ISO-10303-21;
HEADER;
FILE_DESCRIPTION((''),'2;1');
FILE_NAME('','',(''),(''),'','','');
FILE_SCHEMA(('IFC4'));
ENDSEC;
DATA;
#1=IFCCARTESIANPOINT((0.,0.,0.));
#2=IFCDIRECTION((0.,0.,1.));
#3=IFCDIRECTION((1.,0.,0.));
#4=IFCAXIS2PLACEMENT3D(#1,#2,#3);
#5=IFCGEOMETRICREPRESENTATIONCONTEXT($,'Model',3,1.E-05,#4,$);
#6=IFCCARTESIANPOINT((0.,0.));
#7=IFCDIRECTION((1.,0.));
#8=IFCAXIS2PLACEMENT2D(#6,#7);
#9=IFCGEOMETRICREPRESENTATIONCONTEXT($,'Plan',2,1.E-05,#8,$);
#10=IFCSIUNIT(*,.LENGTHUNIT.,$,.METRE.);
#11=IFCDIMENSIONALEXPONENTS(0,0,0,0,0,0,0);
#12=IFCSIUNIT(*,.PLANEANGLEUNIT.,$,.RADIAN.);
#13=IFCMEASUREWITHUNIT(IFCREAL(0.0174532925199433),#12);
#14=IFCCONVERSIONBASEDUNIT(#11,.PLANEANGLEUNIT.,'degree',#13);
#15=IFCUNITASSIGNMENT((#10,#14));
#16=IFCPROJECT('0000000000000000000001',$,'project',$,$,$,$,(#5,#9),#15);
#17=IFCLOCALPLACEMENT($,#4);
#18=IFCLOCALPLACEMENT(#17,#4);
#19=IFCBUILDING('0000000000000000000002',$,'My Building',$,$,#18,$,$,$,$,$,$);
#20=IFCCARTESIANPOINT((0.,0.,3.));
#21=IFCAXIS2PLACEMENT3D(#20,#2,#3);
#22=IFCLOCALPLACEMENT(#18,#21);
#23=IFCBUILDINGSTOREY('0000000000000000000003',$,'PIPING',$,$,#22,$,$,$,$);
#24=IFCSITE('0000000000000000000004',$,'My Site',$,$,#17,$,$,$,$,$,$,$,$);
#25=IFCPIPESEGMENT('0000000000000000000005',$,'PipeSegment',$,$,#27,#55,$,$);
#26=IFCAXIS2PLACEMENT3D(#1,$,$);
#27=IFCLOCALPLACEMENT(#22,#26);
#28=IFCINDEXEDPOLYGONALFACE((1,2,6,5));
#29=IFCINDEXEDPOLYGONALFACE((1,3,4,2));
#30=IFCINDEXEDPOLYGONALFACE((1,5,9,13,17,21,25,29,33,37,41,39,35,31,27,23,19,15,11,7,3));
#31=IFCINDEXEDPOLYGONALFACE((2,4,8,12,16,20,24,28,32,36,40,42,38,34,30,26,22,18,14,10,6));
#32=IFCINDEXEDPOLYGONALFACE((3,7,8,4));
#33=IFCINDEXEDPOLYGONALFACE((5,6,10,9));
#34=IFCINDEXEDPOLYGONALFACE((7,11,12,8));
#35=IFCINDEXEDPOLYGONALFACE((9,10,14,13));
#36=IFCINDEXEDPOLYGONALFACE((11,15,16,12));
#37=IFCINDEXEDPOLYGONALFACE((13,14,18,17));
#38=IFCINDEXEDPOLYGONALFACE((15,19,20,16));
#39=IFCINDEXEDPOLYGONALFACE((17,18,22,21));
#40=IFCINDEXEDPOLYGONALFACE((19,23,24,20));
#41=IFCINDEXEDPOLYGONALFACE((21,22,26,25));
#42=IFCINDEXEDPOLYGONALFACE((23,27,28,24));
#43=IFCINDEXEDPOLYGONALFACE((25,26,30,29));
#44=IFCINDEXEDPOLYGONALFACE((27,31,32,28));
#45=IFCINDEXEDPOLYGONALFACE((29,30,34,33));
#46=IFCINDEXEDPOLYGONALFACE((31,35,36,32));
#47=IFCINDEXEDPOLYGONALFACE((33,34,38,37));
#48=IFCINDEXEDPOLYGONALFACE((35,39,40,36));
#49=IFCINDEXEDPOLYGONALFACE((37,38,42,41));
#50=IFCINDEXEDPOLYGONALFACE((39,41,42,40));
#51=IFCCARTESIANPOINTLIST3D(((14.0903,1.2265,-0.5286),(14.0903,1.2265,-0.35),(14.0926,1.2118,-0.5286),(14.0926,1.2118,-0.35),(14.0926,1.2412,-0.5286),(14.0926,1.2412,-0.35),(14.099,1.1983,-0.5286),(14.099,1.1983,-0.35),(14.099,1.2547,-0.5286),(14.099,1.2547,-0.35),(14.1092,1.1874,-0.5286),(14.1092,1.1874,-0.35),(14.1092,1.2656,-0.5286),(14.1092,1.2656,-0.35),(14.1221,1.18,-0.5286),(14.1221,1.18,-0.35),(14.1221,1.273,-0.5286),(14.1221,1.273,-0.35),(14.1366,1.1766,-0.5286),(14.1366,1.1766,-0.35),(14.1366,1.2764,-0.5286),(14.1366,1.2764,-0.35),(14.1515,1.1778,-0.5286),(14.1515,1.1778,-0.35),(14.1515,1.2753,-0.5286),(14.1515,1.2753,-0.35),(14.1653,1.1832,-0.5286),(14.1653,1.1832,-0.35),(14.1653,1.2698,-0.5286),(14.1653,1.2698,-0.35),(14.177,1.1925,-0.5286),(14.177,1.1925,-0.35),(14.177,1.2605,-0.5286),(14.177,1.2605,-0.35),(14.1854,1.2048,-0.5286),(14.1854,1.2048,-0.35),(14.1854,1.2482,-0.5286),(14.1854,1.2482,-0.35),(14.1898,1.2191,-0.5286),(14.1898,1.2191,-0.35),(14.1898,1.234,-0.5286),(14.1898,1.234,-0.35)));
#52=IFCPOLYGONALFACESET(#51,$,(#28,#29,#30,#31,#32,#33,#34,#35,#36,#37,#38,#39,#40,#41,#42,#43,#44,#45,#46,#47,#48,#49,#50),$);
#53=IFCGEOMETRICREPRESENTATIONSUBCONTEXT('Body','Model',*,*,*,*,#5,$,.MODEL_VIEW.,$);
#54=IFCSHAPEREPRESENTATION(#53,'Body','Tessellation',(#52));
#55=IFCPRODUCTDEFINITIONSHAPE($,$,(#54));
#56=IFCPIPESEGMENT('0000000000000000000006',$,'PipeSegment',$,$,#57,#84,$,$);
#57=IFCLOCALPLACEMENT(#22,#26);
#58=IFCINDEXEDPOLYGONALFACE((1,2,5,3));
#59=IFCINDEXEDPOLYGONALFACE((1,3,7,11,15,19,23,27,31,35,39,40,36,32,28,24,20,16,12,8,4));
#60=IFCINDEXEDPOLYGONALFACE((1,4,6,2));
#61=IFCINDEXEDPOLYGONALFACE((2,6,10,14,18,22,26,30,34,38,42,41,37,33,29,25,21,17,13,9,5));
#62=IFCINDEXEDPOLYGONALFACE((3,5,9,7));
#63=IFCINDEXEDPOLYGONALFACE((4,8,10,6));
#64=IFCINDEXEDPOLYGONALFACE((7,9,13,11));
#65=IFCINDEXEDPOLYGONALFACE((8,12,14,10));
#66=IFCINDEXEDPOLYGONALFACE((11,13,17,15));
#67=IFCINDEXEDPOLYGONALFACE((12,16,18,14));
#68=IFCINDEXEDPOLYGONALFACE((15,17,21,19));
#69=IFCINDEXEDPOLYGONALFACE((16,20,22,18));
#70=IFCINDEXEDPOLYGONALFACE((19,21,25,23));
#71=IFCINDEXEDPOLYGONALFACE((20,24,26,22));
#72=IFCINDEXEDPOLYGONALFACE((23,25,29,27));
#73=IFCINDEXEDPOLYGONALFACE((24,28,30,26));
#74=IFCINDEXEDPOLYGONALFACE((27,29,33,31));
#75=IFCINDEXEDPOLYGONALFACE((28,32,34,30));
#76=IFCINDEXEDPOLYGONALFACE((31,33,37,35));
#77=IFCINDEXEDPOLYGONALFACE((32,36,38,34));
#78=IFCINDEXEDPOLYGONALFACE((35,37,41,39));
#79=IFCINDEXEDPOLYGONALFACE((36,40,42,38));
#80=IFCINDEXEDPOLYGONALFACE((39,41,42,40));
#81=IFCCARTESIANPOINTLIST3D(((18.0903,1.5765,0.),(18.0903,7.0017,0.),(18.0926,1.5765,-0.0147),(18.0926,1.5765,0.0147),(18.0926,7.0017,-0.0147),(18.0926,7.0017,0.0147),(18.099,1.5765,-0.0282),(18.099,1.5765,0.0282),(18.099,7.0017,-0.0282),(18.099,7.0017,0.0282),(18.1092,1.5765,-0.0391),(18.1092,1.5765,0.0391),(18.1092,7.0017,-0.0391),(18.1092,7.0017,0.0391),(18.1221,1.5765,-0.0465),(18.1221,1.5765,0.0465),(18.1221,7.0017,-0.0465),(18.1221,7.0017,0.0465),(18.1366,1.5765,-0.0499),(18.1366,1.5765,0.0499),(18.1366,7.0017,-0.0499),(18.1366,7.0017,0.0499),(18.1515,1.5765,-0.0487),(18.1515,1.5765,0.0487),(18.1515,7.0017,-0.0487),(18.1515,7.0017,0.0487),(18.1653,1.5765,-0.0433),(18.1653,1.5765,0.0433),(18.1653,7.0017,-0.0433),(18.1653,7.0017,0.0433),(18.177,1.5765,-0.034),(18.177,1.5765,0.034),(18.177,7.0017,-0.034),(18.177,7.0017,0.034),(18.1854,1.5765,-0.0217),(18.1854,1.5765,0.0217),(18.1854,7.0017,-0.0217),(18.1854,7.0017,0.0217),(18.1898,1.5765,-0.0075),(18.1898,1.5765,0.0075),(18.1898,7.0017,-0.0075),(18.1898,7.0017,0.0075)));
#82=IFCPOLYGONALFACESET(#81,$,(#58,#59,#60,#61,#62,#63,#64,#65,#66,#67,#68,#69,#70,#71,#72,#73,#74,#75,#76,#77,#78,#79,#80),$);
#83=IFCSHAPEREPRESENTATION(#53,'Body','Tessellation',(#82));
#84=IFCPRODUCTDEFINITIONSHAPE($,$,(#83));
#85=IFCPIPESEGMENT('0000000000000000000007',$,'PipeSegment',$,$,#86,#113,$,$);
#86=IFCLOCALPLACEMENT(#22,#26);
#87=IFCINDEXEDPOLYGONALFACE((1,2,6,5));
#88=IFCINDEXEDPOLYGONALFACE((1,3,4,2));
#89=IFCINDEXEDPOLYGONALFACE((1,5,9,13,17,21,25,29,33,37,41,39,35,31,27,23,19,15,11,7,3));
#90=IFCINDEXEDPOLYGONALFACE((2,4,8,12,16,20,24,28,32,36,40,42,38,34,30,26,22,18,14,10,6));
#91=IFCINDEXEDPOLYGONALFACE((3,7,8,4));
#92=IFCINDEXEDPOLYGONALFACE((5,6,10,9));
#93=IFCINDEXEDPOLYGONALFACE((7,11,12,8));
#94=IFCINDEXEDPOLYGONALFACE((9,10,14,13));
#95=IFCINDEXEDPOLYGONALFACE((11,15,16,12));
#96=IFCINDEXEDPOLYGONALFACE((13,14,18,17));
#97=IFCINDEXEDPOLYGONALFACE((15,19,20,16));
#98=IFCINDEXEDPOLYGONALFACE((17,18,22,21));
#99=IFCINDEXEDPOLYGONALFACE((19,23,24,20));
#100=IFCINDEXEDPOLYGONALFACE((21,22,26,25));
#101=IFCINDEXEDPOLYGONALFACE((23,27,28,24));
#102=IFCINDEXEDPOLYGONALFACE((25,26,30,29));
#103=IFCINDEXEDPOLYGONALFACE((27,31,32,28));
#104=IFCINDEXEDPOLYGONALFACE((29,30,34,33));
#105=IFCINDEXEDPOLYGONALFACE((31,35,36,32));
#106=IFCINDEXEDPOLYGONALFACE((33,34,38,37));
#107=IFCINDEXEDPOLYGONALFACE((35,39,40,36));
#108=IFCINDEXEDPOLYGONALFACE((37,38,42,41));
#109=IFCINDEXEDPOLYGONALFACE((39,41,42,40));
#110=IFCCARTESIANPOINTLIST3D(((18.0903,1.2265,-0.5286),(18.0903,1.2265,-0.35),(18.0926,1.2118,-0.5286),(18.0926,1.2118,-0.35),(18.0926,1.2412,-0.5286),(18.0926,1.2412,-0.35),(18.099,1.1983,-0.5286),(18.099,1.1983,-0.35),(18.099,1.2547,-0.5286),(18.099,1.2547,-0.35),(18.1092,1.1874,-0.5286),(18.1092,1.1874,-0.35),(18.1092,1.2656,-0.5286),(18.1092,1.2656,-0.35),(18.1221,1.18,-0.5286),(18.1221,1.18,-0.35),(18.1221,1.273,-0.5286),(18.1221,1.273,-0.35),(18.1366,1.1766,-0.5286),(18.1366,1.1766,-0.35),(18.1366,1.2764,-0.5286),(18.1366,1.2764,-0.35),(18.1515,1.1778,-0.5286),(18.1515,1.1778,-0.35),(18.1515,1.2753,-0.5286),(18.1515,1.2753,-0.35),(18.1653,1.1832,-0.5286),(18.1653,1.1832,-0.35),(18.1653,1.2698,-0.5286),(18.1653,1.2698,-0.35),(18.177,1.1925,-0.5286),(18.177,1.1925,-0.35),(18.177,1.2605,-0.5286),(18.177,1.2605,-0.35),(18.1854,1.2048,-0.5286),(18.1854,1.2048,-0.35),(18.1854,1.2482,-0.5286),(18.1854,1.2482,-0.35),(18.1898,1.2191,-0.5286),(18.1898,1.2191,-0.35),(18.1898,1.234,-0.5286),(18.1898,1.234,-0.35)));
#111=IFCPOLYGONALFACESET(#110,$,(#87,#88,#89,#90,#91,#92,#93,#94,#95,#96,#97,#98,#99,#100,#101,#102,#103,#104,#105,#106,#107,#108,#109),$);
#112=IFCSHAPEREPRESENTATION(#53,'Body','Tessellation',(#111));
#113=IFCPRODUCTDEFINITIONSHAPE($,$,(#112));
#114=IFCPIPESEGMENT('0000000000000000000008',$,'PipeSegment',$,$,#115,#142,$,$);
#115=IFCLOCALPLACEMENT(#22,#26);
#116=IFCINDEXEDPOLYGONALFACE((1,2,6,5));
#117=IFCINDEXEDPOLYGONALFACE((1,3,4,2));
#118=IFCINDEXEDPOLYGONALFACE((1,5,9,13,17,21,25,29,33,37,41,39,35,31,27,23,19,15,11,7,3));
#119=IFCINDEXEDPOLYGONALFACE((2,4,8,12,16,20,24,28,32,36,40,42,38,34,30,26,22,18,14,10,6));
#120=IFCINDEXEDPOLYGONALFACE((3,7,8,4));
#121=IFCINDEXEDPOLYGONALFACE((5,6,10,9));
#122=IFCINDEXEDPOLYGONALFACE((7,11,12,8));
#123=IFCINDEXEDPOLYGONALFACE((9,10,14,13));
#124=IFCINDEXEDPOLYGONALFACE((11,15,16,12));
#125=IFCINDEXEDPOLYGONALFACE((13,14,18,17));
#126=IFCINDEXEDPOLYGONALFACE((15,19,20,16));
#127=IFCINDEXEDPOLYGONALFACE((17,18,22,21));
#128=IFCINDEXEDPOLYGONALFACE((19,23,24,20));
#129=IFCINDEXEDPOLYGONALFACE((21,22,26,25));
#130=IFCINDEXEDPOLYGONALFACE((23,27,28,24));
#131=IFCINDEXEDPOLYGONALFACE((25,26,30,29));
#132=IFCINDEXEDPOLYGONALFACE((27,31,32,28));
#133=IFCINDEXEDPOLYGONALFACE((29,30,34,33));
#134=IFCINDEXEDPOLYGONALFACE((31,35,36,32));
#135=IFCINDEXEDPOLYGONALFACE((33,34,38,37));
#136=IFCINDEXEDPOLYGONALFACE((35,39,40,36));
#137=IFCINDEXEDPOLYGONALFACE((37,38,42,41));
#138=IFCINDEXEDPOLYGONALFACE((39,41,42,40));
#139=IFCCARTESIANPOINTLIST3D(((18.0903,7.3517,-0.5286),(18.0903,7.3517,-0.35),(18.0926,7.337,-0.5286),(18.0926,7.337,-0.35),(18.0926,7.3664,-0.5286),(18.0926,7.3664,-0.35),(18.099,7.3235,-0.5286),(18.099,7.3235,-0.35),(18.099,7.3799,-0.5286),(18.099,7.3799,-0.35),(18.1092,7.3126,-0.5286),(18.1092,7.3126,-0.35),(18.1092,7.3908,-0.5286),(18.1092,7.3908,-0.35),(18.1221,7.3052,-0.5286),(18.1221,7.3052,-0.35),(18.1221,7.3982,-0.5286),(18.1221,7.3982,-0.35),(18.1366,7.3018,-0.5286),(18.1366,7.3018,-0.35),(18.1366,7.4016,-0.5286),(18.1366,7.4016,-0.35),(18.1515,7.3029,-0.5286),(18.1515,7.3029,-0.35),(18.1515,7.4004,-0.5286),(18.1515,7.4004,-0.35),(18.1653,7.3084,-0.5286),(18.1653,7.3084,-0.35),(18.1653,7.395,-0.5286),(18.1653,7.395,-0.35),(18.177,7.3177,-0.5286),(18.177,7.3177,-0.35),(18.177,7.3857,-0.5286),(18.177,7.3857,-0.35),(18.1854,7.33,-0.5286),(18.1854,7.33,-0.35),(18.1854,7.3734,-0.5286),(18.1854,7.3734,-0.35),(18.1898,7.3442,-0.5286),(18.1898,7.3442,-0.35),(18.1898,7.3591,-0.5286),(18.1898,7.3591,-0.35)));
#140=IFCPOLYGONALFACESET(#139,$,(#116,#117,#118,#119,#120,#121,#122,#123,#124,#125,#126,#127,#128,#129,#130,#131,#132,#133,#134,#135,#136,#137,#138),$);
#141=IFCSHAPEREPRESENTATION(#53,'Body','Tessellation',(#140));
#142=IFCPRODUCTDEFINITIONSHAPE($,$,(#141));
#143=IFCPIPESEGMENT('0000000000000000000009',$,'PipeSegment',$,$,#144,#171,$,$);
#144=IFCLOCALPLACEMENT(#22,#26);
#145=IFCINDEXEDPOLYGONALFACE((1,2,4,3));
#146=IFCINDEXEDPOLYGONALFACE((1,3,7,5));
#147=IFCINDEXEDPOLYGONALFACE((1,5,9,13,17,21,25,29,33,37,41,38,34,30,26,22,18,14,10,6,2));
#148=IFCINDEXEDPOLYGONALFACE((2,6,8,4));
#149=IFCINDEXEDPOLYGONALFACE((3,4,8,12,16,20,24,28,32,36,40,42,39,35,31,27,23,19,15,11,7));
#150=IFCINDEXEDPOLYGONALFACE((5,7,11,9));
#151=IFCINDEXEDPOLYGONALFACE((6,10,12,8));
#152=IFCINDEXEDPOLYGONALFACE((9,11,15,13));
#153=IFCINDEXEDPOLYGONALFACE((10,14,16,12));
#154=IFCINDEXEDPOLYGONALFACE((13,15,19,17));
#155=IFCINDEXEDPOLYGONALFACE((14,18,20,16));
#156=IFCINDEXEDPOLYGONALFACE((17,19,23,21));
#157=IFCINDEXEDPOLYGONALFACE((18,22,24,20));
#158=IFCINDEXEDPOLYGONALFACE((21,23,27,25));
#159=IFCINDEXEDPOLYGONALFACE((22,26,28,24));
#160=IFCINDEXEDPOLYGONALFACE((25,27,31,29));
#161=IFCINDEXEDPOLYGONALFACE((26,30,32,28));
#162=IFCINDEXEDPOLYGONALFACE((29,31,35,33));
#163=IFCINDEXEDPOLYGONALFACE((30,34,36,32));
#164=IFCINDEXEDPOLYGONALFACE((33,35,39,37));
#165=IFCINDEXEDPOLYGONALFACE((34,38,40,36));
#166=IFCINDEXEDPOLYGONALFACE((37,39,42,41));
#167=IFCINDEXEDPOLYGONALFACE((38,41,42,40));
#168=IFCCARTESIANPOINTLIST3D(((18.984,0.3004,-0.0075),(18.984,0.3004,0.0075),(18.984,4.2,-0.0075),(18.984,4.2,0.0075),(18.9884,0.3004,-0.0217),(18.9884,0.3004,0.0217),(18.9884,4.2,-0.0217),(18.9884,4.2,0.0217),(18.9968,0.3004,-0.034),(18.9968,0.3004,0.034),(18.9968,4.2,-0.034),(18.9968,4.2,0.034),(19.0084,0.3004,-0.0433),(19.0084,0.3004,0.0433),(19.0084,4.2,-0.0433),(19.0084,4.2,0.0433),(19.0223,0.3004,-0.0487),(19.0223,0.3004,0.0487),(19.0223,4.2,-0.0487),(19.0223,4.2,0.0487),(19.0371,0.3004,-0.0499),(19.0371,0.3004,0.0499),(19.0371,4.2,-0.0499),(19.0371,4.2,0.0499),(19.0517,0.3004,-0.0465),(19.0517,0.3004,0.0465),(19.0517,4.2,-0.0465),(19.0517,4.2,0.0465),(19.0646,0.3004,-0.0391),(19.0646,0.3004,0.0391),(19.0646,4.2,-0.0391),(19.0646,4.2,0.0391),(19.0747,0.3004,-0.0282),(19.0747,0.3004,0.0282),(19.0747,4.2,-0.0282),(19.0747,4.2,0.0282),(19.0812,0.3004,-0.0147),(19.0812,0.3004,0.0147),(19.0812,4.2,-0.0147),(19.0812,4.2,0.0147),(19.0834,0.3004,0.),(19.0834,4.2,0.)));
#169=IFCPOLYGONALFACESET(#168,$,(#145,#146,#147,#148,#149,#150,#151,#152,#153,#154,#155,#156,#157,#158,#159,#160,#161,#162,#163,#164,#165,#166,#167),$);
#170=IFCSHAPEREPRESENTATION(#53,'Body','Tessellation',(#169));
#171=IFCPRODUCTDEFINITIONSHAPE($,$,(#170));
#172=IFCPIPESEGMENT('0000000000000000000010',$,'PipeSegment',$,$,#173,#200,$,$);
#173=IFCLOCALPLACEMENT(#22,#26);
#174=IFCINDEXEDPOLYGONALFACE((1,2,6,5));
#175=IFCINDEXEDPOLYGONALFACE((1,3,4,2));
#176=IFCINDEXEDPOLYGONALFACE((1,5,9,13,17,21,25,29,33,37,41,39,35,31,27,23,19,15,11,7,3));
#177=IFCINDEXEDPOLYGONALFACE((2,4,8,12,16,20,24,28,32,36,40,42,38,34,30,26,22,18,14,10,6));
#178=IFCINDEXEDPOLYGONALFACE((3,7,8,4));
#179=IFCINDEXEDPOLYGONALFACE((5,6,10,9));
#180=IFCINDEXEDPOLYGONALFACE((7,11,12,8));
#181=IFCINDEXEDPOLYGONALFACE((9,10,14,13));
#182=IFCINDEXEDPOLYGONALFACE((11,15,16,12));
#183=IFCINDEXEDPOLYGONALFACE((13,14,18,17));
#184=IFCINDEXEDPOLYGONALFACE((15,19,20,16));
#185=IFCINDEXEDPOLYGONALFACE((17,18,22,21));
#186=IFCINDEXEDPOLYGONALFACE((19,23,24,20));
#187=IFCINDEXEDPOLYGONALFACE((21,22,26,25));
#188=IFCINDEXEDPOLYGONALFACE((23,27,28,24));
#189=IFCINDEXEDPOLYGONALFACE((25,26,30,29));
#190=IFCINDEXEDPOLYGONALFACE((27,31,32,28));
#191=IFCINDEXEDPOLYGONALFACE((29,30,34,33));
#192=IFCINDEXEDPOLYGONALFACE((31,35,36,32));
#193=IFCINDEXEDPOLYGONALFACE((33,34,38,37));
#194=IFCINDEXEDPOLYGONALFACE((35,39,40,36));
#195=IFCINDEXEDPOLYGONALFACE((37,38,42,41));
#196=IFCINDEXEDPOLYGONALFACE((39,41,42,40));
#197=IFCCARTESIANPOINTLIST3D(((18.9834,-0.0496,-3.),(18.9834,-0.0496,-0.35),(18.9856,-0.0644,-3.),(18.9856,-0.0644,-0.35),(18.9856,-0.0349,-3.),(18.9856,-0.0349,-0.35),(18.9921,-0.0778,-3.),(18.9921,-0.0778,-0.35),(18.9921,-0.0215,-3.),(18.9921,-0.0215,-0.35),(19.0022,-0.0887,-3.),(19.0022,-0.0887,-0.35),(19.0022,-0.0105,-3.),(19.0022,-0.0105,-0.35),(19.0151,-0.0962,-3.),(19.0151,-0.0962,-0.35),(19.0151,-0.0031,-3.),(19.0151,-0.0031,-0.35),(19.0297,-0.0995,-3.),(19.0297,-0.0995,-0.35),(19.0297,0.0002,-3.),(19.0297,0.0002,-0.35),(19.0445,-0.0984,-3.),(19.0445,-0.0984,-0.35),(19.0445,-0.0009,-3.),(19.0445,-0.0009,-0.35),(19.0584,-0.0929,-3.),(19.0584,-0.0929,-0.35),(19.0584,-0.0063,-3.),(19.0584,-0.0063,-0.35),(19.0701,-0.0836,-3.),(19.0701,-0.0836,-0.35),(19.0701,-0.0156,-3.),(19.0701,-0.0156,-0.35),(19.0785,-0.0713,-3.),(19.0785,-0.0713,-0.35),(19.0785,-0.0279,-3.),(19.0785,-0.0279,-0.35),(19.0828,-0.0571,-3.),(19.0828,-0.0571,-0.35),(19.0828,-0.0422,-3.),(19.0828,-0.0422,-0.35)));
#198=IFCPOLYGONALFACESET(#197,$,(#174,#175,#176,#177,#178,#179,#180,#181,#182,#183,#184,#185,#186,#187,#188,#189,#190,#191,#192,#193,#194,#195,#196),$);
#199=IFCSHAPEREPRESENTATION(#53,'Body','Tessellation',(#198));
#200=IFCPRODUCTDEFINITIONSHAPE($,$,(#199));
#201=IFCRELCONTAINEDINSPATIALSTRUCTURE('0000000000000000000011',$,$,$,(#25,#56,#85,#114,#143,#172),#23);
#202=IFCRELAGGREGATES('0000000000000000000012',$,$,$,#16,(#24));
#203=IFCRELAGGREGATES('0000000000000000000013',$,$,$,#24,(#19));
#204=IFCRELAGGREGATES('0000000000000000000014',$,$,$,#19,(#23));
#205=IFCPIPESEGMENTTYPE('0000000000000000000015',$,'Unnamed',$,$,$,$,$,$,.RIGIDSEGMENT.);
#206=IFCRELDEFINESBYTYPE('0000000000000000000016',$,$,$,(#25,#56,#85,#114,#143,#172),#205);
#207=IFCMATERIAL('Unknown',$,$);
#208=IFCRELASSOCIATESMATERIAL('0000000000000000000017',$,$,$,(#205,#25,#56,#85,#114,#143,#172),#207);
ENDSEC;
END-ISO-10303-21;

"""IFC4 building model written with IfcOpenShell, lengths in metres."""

from ifc_helpers import new_model, entity, si_unit, converted_unit, frame, origin_with_axes, origin_2d_with_axis, place, context, subcontext, project, spatial, circle, extrude, material, material_profile, profile_set, profile_usage, type_object, element, save


model = new_model("IFC4")

# Units and contexts
model_context = context("Model", 3, precision=1e-05, world=origin_with_axes())
plan_context = context("Plan", 2, precision=1e-05, world=origin_2d_with_axis())
body_context = subcontext(model_context, "Body", "Model", "MODEL_VIEW")
ifc_project = project(units=[si_unit("LENGTHUNIT", "METRE"), converted_unit("PLANEANGLEUNIT", "degree", entity("IfcReal", 0.0174532925199433), si_unit("PLANEANGLEUNIT", "RADIAN"), dimensions=[0, 0, 0, 0, 0, 0, 0])], contexts=[model_context, plan_context])

# Site, building, storey
site_placement = place(None, origin_with_axes())
site = spatial("IfcSite", under=ifc_project, at=site_placement, Name="My Site")
building_placement = place(site_placement, origin_with_axes())
building = spatial("IfcBuilding", under=site, at=building_placement, Name="My Building")
storey_placement = place(building_placement, frame((0.0, 0.0, 3.0), z_axis=(0.0, 0.0, 1.0), x_axis=(1.0, 0.0, 0.0)))
storey = spatial("IfcBuildingStorey", under=building, at=storey_placement, Name="PIPING")

# Pipe segments
ifc_material = material(Name="Unknown")
ifc_material_profile = material_profile(ifc_material, circle(Radius=0.05))
ifc_profile_set = profile_set([ifc_material_profile])
pipe_segment_type = type_object("IfcPipeSegmentType", Name="Unnamed", PredefinedType="RIGIDSEGMENT", material=ifc_profile_set)
ifc_profile_usage_1 = profile_usage(ifc_profile_set, cardinal=5)
pipe_segment_1_placement = place(storey_placement, frame((14.1403, 1.2265, -0.35), z_axis=(0.0, 0.0, -1.0), x_axis=(-1.0, 0.0, 0.0)))
element("IfcPipeSegment", 1, at=pipe_segment_1_placement, inside=storey, type_object=pipe_segment_type, material=ifc_profile_usage_1, Name="PipeSegment", context=body_context, shape_type="SweptSolid", body=[
    extrude(circle(Radius=0.05), origin_with_axes(), (0.0, 0.0, 1.0), 0.1786),
])
ifc_profile_usage_2 = profile_usage(ifc_profile_set, cardinal=5)
pipe_segment_2_placement = place(storey_placement, frame((18.1403, 1.5765, 0.0), z_axis=(0.0, 1.0, 0.0), x_axis=(-1.0, 0.0, 0.0)))
element("IfcPipeSegment", 2, at=pipe_segment_2_placement, inside=storey, type_object=pipe_segment_type, material=ifc_profile_usage_2, Name="PipeSegment", context=body_context, shape_type="SweptSolid", body=[
    extrude(circle(Radius=0.05), origin_with_axes(), (0.0, 0.0, 1.0), 5.4252),
])
ifc_profile_usage_3 = profile_usage(ifc_profile_set, cardinal=5)
pipe_segment_3_placement = place(storey_placement, frame((18.1403, 1.2265, -0.35), z_axis=(0.0, 0.0, -1.0), x_axis=(-1.0, 0.0, 0.0)))
element("IfcPipeSegment", 3, at=pipe_segment_3_placement, inside=storey, type_object=pipe_segment_type, material=ifc_profile_usage_3, Name="PipeSegment", context=body_context, shape_type="SweptSolid", body=[
    extrude(circle(Radius=0.05), origin_with_axes(), (0.0, 0.0, 1.0), 0.1786),
])
ifc_profile_usage_4 = profile_usage(ifc_profile_set, cardinal=5)
pipe_segment_4_placement = place(storey_placement, frame((18.1403, 7.3517, -0.35), z_axis=(0.0, 0.0, -1.0), x_axis=(-1.0, 0.0, 0.0)))
element("IfcPipeSegment", 4, at=pipe_segment_4_placement, inside=storey, type_object=pipe_segment_type, material=ifc_profile_usage_4, Name="PipeSegment", context=body_context, shape_type="SweptSolid", body=[
    extrude(circle(Radius=0.05), origin_with_axes(), (0.0, 0.0, 1.0), 0.1786),
])
ifc_profile_usage_5 = profile_usage(ifc_profile_set, cardinal=5)
pipe_segment_5_placement = place(storey_placement, frame((19.0334, 4.2, 0.0), z_axis=(0.0, -1.0, 0.0), x_axis=(1.0, 0.0, 0.0)))
element("IfcPipeSegment", 5, at=pipe_segment_5_placement, inside=storey, type_object=pipe_segment_type, material=ifc_profile_usage_5, Name="PipeSegment", context=body_context, shape_type="SweptSolid", body=[
    extrude(circle(Radius=0.05), origin_with_axes(), (0.0, 0.0, 1.0), 3.8996),
])
ifc_profile_usage_6 = profile_usage(ifc_profile_set, cardinal=5)
pipe_segment_6_placement = place(storey_placement, frame((19.0334, -0.0496, -0.35), z_axis=(0.0, 0.0, -1.0), x_axis=(-1.0, 0.0, 0.0)))
element("IfcPipeSegment", 6, at=pipe_segment_6_placement, inside=storey, type_object=pipe_segment_type, material=ifc_profile_usage_6, Name="PipeSegment", context=body_context, shape_type="SweptSolid", body=[
    extrude(circle(Radius=0.05), origin_with_axes(), (0.0, 0.0, 1.0), 2.65),
])

save(model, "model.ifc")
